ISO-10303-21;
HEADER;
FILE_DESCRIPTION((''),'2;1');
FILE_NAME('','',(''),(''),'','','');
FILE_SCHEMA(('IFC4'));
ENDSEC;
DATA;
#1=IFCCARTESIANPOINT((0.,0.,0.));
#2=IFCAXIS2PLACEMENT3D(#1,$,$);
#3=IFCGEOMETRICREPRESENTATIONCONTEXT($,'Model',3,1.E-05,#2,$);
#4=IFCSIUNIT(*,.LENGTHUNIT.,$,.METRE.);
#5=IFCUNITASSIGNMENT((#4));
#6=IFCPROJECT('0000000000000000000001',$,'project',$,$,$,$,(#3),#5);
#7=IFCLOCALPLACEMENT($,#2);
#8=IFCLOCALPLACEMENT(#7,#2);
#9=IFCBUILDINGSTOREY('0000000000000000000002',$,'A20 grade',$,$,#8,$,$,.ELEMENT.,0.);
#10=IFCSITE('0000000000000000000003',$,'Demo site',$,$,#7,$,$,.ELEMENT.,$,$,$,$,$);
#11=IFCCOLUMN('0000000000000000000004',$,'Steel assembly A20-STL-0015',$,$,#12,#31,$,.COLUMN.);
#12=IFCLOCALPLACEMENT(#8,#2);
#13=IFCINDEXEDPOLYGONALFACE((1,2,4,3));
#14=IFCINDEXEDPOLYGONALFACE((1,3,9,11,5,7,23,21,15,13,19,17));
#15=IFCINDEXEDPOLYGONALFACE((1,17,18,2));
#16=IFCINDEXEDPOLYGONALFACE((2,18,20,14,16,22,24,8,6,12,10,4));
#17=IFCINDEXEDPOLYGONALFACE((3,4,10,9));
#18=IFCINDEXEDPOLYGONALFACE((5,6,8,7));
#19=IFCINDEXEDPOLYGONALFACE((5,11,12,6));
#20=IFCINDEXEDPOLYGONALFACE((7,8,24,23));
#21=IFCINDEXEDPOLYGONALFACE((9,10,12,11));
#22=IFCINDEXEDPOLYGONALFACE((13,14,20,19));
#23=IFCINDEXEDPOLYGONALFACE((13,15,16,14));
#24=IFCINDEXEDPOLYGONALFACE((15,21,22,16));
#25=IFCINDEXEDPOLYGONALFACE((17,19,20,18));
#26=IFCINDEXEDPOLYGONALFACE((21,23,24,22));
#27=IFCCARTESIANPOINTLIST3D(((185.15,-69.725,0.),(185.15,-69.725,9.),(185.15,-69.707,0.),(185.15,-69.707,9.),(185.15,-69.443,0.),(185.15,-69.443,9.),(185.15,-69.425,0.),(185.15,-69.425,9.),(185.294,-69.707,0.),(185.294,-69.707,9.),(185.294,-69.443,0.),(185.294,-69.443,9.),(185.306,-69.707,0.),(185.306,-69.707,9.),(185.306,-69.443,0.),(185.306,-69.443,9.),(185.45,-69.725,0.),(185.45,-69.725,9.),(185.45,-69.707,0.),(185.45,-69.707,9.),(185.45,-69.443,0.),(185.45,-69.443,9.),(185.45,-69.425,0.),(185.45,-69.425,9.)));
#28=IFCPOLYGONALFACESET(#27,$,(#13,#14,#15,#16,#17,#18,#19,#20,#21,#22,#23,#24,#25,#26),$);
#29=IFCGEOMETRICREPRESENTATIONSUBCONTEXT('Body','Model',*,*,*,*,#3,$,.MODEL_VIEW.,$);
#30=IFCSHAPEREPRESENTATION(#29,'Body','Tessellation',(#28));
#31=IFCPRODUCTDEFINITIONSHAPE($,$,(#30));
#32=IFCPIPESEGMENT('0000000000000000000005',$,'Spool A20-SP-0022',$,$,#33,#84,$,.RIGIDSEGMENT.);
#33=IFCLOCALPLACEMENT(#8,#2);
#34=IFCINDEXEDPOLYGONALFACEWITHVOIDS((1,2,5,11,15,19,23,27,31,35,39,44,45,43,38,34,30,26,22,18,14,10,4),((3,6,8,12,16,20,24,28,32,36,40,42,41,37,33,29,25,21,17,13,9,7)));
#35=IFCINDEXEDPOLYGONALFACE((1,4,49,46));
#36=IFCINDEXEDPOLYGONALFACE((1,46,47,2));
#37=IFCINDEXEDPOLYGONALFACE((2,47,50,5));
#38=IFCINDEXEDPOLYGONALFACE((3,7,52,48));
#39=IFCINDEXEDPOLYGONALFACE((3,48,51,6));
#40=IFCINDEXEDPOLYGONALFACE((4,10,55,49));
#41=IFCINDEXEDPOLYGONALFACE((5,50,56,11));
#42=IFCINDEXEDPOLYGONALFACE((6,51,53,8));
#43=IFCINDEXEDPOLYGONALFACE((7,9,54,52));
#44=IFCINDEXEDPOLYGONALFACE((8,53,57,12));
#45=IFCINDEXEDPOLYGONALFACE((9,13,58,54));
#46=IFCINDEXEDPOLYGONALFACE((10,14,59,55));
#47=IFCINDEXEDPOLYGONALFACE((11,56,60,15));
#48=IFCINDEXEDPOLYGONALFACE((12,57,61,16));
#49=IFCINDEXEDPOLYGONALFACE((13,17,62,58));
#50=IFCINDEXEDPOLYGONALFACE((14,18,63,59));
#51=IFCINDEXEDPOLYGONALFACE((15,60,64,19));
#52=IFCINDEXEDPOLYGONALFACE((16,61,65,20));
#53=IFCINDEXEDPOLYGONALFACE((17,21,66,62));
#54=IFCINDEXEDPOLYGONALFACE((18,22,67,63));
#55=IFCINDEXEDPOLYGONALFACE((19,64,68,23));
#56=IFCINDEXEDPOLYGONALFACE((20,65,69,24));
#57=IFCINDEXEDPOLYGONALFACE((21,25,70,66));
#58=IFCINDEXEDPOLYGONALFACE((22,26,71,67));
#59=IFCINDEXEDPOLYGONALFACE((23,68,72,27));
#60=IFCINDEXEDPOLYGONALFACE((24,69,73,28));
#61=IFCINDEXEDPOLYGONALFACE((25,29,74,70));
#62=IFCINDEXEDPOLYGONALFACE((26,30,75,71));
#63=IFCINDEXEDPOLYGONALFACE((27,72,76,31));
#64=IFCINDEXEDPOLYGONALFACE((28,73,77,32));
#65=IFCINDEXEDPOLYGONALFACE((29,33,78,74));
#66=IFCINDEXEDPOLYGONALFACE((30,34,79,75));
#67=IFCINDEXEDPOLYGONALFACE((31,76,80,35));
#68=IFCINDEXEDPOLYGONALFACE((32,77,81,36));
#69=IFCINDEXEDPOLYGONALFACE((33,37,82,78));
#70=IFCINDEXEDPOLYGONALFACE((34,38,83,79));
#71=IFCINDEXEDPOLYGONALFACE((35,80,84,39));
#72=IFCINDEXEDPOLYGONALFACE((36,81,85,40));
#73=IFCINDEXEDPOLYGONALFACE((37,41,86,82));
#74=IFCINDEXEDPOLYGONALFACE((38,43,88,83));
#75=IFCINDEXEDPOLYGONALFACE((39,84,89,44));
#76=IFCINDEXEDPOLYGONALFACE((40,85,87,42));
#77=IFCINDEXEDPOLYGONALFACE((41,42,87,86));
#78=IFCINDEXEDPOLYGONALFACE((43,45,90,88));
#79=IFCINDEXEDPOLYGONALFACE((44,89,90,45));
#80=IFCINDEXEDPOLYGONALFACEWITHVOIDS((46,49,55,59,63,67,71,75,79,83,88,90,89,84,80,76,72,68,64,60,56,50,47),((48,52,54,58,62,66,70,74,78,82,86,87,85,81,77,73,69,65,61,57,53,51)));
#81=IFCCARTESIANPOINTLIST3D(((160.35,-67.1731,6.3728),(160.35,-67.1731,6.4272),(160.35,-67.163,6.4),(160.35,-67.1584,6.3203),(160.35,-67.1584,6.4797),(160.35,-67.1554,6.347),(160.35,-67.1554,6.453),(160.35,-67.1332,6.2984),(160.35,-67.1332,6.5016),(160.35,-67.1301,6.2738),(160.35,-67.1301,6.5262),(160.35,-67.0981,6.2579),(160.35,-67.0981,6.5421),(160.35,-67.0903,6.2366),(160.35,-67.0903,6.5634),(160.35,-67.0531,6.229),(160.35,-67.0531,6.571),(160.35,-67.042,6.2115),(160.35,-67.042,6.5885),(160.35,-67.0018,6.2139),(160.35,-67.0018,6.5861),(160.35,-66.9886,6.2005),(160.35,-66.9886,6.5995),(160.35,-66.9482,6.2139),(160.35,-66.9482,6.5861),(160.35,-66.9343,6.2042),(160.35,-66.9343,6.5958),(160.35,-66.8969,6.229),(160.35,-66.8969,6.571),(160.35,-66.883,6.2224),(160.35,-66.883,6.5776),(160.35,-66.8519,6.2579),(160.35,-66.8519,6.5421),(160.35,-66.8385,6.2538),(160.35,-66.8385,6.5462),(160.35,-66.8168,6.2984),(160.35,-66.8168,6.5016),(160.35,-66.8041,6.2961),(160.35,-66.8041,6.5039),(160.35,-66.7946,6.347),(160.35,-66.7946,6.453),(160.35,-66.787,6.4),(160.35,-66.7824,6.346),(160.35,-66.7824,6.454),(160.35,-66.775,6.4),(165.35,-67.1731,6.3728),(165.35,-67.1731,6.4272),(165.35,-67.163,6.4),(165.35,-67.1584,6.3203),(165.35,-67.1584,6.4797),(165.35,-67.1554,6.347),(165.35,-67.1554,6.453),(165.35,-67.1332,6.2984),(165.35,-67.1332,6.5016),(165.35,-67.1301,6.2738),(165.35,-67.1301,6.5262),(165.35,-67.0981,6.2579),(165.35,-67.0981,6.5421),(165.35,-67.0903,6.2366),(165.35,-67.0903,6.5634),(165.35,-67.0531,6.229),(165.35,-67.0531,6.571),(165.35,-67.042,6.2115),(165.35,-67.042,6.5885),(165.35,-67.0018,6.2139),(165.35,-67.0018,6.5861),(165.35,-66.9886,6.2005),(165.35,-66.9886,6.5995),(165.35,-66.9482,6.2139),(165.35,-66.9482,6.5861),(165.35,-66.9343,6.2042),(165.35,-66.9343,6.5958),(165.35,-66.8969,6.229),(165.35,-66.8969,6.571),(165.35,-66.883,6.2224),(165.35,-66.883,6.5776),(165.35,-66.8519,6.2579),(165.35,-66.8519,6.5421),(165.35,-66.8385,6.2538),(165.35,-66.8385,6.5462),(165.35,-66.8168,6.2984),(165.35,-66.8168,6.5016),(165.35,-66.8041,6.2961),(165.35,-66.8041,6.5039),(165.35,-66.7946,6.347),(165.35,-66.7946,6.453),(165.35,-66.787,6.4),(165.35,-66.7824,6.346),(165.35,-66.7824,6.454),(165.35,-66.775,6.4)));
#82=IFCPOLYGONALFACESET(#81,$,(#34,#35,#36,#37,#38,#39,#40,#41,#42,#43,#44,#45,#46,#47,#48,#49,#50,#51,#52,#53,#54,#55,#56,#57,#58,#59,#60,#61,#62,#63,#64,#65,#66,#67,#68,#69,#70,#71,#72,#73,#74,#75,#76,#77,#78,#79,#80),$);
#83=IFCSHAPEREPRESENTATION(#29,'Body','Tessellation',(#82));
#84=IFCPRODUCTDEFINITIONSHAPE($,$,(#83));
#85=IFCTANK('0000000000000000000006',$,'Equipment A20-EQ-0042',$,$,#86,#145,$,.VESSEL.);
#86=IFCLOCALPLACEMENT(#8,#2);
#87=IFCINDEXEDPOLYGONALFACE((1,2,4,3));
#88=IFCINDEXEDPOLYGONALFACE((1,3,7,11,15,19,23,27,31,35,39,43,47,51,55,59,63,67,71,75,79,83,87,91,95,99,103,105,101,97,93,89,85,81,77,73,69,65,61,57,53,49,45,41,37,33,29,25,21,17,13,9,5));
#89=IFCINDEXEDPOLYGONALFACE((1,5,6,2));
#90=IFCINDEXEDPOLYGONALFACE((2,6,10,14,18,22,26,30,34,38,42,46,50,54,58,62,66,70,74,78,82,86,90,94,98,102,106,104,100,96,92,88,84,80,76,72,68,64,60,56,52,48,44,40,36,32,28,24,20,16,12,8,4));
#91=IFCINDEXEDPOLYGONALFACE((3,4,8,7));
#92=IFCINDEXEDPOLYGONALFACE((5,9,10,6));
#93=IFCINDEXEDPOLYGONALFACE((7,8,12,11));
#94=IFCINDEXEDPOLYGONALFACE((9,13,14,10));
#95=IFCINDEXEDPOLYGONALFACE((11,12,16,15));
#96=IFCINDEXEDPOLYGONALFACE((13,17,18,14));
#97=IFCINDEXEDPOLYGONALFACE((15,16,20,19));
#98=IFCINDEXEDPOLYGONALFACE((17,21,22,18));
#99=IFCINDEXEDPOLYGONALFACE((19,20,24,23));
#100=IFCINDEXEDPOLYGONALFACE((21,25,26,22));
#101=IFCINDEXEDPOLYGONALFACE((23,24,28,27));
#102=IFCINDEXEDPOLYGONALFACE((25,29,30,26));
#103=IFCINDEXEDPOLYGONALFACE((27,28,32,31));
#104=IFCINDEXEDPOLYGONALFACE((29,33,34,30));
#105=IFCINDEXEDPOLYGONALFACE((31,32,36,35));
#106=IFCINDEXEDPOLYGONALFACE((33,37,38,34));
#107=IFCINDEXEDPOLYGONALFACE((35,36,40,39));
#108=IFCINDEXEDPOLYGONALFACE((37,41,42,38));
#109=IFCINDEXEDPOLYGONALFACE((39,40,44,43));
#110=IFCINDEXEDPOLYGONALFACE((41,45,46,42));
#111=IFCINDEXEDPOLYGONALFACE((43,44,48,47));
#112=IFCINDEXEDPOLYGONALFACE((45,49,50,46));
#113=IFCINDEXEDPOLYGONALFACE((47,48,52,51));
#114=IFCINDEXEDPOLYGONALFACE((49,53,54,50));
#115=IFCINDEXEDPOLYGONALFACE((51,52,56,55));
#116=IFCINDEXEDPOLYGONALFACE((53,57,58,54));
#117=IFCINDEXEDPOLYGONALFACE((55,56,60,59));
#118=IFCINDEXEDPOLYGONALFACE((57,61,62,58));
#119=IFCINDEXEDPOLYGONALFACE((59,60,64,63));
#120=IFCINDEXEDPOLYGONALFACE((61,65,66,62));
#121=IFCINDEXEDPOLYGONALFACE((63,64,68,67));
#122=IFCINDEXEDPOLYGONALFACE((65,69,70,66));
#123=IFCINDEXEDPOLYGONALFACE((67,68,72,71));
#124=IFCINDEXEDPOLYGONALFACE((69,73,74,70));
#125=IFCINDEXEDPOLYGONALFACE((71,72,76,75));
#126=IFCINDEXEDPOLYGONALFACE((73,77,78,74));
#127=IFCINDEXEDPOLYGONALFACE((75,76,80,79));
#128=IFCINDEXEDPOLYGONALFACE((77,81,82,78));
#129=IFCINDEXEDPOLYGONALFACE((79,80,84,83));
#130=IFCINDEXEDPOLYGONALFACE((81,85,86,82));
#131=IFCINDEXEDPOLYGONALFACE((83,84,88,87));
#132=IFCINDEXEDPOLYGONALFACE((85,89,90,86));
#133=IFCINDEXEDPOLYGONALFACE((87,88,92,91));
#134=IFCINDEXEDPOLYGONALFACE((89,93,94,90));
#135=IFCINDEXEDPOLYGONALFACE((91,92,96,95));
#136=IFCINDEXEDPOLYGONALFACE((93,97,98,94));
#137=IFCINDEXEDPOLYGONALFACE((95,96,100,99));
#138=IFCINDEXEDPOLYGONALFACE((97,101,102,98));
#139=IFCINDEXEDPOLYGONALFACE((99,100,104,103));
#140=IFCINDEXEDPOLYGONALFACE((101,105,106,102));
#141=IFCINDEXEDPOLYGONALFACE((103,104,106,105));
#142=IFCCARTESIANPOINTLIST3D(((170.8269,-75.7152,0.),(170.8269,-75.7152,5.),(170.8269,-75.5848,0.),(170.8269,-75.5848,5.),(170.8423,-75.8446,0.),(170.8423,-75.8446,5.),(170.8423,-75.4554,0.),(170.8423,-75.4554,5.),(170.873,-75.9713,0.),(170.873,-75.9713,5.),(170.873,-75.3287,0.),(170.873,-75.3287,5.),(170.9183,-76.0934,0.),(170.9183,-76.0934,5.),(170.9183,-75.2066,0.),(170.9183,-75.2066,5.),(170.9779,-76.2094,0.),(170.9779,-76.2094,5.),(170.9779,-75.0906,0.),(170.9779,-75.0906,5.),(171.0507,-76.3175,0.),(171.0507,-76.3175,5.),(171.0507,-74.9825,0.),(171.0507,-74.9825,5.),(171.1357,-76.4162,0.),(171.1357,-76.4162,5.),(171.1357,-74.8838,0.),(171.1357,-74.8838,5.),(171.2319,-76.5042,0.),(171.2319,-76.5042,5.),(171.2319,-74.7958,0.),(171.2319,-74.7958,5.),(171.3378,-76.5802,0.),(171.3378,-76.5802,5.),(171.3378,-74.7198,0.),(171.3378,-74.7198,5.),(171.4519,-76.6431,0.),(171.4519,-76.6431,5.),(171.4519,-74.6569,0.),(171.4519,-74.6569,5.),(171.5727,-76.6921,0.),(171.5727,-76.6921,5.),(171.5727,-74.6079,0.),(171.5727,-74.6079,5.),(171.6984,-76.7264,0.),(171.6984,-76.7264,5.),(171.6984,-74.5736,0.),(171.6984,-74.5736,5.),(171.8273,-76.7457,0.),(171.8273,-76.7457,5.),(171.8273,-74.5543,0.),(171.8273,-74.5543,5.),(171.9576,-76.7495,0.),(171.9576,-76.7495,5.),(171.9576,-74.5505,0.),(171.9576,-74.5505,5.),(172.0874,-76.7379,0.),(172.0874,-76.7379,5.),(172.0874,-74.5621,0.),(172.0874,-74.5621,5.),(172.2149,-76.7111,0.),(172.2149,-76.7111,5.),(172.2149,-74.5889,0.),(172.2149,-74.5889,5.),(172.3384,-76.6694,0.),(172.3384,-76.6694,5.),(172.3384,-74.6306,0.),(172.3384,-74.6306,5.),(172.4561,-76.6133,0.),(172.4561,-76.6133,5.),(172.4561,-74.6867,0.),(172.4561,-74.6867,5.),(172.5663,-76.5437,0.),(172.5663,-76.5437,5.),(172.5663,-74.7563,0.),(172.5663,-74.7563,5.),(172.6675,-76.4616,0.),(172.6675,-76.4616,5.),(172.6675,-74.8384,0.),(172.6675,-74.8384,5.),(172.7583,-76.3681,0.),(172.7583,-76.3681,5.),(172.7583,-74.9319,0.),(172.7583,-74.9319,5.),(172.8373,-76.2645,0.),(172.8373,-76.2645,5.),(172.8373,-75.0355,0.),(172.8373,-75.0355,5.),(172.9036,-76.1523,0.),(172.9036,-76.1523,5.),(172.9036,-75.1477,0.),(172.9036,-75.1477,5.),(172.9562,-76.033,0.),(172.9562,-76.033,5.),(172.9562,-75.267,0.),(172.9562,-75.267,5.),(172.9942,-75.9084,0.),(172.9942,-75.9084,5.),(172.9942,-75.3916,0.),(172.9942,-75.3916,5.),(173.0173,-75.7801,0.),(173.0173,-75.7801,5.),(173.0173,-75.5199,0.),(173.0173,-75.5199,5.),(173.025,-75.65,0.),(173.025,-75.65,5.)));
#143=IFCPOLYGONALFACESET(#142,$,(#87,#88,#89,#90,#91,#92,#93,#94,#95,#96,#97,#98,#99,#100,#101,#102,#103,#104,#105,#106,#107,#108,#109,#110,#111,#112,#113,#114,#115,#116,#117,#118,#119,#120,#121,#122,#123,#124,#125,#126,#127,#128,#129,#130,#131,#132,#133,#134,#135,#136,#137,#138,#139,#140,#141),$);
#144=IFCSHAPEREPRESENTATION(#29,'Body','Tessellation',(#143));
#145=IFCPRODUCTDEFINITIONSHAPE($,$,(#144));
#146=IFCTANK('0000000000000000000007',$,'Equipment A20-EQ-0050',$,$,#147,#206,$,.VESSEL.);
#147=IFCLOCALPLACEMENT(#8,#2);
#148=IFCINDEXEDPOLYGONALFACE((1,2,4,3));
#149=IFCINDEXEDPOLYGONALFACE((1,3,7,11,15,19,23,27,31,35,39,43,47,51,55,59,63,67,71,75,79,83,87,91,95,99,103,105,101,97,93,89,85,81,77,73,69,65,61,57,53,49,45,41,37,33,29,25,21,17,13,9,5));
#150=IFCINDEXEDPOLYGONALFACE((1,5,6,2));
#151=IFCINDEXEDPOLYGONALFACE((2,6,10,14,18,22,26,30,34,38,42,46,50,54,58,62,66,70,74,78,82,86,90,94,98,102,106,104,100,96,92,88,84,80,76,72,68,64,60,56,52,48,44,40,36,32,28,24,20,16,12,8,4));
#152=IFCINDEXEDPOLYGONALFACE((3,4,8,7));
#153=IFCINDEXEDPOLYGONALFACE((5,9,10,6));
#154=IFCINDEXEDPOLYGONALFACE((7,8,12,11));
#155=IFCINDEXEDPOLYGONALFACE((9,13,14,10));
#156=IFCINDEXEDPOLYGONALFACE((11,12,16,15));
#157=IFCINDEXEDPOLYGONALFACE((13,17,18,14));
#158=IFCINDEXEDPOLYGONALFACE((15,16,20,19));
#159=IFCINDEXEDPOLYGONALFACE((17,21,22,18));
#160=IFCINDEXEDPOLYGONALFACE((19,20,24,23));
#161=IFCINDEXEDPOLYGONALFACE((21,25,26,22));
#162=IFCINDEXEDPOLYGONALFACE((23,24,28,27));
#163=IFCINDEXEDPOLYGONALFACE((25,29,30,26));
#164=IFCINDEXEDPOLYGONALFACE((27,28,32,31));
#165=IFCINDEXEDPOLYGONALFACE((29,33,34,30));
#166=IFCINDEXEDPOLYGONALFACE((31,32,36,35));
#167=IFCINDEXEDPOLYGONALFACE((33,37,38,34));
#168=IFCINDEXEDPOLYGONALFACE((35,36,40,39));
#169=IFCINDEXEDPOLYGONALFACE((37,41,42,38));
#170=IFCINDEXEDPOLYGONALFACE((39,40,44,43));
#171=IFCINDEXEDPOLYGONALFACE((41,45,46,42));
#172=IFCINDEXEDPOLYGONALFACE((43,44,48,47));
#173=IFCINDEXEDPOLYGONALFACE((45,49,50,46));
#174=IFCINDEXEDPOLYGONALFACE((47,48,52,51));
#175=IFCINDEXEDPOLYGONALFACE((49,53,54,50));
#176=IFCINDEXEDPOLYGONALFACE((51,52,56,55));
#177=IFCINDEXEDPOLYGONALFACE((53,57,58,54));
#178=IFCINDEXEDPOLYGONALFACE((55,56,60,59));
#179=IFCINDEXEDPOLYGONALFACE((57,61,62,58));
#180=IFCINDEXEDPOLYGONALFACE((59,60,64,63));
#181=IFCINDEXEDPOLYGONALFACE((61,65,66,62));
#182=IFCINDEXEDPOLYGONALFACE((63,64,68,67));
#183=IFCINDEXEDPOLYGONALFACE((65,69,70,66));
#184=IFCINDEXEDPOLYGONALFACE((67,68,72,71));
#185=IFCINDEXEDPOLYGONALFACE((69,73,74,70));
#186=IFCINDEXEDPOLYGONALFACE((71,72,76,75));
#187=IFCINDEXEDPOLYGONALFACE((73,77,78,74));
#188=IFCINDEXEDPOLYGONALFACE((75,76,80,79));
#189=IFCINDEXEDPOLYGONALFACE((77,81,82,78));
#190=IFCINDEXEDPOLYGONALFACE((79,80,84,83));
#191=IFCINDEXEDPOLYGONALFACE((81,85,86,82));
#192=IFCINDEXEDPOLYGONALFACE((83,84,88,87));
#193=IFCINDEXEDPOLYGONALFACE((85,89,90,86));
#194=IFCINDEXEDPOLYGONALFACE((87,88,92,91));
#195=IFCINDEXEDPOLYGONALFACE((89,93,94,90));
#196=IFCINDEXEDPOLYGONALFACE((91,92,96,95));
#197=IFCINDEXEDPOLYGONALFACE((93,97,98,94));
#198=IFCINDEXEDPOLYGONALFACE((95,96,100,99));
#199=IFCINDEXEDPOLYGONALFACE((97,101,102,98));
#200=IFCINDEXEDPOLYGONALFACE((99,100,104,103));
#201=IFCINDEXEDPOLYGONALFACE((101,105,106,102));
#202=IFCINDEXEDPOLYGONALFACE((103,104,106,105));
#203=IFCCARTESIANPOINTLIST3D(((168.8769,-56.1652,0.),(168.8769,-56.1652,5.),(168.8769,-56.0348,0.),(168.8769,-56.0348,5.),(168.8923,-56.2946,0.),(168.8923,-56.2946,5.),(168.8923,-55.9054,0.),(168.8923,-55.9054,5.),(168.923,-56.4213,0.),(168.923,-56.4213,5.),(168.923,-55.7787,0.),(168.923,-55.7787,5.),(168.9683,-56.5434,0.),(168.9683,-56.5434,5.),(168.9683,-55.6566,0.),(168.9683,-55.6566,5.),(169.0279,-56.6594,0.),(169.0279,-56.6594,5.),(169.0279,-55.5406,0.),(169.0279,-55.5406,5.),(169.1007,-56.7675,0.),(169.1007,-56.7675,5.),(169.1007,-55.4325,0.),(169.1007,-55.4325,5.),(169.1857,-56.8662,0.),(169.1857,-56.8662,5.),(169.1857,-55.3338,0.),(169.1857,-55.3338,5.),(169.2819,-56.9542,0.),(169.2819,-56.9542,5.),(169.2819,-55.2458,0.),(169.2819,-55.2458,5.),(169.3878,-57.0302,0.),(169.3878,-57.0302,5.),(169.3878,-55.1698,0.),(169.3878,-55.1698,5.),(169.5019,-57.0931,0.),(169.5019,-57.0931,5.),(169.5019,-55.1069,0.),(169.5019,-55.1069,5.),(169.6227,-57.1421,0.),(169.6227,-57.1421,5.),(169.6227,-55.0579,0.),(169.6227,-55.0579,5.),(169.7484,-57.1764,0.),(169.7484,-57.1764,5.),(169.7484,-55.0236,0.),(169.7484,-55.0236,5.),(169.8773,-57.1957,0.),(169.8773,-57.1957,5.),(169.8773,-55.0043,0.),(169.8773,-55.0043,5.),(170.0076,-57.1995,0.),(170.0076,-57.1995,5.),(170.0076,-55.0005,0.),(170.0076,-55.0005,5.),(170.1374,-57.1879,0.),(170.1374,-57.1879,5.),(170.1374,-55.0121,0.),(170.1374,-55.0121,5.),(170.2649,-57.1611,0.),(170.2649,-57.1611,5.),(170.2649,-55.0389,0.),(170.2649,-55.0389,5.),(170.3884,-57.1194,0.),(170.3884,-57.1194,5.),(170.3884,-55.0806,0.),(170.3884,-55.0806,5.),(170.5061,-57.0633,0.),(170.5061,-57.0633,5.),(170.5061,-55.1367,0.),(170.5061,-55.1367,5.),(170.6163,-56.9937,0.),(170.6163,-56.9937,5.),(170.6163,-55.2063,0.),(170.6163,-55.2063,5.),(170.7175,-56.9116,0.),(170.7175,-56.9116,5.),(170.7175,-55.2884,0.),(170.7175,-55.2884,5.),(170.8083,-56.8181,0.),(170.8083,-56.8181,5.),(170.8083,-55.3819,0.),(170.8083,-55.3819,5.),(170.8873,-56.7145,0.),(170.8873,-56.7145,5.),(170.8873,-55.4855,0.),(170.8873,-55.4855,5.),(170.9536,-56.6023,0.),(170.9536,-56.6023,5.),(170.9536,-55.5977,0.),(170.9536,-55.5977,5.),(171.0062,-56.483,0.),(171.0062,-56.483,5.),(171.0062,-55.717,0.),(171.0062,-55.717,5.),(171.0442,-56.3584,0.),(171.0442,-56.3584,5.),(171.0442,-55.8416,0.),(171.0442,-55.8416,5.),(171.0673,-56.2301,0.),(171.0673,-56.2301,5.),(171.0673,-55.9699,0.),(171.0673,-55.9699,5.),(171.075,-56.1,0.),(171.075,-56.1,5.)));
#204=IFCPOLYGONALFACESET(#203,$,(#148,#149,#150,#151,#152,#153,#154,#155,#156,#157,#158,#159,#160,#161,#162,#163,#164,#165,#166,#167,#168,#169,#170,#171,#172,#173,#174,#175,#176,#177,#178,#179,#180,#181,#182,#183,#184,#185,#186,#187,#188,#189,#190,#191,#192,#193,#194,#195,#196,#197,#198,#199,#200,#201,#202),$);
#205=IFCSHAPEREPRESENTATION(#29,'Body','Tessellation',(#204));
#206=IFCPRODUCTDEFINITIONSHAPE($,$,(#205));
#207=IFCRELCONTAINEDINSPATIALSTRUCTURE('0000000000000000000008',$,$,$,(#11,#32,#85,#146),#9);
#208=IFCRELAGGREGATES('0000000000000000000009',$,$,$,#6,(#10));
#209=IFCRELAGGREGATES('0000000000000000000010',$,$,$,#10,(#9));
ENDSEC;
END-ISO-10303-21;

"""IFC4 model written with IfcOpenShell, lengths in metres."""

from ifc_helpers import new_model, si_unit, frame, origin, place, context, subcontext, project, spatial, circle, hollow_circle, i_section, extrude, element, save


model = new_model("IFC4")

# Units and contexts
model_context = context("Model", 3, precision=1e-05, world=origin())
body_context = subcontext(model_context, "Body", "Model", "MODEL_VIEW")
ifc_project = project(units=[si_unit("LENGTHUNIT", "METRE")], contexts=[model_context])

# Site, storey
site_placement = place(None, origin())
site = spatial("IfcSite", under=ifc_project, at=site_placement, Name="Demo site", CompositionType="ELEMENT")
storey_placement = place(site_placement, origin())
storey = spatial("IfcBuildingStorey", under=site, at=storey_placement, Name="A20 grade", CompositionType="ELEMENT", Elevation=0.0)

# Column
for number, where, name in (
    (1, (185.3, -69.575, 0.0), "Steel assembly A20-STL-0015"),
):
    element("IfcColumn", number, at=place(storey_placement, frame(where)), inside=storey, Name=name, PredefinedType="COLUMN", context=body_context, shape_type="SweptSolid", body=[
        extrude(i_section(OverallWidth=0.3, OverallDepth=0.3, WebThickness=0.012, FlangeThickness=0.018), origin(), (0.0, 0.0, 1.0), 9.0),
    ])

# Pipe segment
pipe_segment_1_placement = place(storey_placement, frame((160.35, -66.975, 6.4)))
element("IfcPipeSegment", 2, at=pipe_segment_1_placement, inside=storey, Name="Spool A20-SP-0022", PredefinedType="RIGIDSEGMENT", context=body_context, shape_type="SweptSolid", body=[
    extrude(hollow_circle(Radius=0.2, WallThickness=0.012), frame((0.0, 0.0, 0.0), z_axis=(1.0, 0.0, 0.0), x_axis=(0.0, 1.0, 0.0)), (0.0, 0.0, 1.0), 5.0),
])

# Tanks
for number, where, name in (
    (3, (171.925, -75.65, 0.0), "Equipment A20-EQ-0042"),
    (4, (169.975, -56.1, 0.0), "Equipment A20-EQ-0050"),
):
    element("IfcTank", number, at=place(storey_placement, frame(where)), inside=storey, Name=name, PredefinedType="VESSEL", context=body_context, shape_type="SweptSolid", body=[
        extrude(circle(Radius=1.1), origin(), (0.0, 0.0, 1.0), 5.0),
    ])

save(model, "model.ifc")
